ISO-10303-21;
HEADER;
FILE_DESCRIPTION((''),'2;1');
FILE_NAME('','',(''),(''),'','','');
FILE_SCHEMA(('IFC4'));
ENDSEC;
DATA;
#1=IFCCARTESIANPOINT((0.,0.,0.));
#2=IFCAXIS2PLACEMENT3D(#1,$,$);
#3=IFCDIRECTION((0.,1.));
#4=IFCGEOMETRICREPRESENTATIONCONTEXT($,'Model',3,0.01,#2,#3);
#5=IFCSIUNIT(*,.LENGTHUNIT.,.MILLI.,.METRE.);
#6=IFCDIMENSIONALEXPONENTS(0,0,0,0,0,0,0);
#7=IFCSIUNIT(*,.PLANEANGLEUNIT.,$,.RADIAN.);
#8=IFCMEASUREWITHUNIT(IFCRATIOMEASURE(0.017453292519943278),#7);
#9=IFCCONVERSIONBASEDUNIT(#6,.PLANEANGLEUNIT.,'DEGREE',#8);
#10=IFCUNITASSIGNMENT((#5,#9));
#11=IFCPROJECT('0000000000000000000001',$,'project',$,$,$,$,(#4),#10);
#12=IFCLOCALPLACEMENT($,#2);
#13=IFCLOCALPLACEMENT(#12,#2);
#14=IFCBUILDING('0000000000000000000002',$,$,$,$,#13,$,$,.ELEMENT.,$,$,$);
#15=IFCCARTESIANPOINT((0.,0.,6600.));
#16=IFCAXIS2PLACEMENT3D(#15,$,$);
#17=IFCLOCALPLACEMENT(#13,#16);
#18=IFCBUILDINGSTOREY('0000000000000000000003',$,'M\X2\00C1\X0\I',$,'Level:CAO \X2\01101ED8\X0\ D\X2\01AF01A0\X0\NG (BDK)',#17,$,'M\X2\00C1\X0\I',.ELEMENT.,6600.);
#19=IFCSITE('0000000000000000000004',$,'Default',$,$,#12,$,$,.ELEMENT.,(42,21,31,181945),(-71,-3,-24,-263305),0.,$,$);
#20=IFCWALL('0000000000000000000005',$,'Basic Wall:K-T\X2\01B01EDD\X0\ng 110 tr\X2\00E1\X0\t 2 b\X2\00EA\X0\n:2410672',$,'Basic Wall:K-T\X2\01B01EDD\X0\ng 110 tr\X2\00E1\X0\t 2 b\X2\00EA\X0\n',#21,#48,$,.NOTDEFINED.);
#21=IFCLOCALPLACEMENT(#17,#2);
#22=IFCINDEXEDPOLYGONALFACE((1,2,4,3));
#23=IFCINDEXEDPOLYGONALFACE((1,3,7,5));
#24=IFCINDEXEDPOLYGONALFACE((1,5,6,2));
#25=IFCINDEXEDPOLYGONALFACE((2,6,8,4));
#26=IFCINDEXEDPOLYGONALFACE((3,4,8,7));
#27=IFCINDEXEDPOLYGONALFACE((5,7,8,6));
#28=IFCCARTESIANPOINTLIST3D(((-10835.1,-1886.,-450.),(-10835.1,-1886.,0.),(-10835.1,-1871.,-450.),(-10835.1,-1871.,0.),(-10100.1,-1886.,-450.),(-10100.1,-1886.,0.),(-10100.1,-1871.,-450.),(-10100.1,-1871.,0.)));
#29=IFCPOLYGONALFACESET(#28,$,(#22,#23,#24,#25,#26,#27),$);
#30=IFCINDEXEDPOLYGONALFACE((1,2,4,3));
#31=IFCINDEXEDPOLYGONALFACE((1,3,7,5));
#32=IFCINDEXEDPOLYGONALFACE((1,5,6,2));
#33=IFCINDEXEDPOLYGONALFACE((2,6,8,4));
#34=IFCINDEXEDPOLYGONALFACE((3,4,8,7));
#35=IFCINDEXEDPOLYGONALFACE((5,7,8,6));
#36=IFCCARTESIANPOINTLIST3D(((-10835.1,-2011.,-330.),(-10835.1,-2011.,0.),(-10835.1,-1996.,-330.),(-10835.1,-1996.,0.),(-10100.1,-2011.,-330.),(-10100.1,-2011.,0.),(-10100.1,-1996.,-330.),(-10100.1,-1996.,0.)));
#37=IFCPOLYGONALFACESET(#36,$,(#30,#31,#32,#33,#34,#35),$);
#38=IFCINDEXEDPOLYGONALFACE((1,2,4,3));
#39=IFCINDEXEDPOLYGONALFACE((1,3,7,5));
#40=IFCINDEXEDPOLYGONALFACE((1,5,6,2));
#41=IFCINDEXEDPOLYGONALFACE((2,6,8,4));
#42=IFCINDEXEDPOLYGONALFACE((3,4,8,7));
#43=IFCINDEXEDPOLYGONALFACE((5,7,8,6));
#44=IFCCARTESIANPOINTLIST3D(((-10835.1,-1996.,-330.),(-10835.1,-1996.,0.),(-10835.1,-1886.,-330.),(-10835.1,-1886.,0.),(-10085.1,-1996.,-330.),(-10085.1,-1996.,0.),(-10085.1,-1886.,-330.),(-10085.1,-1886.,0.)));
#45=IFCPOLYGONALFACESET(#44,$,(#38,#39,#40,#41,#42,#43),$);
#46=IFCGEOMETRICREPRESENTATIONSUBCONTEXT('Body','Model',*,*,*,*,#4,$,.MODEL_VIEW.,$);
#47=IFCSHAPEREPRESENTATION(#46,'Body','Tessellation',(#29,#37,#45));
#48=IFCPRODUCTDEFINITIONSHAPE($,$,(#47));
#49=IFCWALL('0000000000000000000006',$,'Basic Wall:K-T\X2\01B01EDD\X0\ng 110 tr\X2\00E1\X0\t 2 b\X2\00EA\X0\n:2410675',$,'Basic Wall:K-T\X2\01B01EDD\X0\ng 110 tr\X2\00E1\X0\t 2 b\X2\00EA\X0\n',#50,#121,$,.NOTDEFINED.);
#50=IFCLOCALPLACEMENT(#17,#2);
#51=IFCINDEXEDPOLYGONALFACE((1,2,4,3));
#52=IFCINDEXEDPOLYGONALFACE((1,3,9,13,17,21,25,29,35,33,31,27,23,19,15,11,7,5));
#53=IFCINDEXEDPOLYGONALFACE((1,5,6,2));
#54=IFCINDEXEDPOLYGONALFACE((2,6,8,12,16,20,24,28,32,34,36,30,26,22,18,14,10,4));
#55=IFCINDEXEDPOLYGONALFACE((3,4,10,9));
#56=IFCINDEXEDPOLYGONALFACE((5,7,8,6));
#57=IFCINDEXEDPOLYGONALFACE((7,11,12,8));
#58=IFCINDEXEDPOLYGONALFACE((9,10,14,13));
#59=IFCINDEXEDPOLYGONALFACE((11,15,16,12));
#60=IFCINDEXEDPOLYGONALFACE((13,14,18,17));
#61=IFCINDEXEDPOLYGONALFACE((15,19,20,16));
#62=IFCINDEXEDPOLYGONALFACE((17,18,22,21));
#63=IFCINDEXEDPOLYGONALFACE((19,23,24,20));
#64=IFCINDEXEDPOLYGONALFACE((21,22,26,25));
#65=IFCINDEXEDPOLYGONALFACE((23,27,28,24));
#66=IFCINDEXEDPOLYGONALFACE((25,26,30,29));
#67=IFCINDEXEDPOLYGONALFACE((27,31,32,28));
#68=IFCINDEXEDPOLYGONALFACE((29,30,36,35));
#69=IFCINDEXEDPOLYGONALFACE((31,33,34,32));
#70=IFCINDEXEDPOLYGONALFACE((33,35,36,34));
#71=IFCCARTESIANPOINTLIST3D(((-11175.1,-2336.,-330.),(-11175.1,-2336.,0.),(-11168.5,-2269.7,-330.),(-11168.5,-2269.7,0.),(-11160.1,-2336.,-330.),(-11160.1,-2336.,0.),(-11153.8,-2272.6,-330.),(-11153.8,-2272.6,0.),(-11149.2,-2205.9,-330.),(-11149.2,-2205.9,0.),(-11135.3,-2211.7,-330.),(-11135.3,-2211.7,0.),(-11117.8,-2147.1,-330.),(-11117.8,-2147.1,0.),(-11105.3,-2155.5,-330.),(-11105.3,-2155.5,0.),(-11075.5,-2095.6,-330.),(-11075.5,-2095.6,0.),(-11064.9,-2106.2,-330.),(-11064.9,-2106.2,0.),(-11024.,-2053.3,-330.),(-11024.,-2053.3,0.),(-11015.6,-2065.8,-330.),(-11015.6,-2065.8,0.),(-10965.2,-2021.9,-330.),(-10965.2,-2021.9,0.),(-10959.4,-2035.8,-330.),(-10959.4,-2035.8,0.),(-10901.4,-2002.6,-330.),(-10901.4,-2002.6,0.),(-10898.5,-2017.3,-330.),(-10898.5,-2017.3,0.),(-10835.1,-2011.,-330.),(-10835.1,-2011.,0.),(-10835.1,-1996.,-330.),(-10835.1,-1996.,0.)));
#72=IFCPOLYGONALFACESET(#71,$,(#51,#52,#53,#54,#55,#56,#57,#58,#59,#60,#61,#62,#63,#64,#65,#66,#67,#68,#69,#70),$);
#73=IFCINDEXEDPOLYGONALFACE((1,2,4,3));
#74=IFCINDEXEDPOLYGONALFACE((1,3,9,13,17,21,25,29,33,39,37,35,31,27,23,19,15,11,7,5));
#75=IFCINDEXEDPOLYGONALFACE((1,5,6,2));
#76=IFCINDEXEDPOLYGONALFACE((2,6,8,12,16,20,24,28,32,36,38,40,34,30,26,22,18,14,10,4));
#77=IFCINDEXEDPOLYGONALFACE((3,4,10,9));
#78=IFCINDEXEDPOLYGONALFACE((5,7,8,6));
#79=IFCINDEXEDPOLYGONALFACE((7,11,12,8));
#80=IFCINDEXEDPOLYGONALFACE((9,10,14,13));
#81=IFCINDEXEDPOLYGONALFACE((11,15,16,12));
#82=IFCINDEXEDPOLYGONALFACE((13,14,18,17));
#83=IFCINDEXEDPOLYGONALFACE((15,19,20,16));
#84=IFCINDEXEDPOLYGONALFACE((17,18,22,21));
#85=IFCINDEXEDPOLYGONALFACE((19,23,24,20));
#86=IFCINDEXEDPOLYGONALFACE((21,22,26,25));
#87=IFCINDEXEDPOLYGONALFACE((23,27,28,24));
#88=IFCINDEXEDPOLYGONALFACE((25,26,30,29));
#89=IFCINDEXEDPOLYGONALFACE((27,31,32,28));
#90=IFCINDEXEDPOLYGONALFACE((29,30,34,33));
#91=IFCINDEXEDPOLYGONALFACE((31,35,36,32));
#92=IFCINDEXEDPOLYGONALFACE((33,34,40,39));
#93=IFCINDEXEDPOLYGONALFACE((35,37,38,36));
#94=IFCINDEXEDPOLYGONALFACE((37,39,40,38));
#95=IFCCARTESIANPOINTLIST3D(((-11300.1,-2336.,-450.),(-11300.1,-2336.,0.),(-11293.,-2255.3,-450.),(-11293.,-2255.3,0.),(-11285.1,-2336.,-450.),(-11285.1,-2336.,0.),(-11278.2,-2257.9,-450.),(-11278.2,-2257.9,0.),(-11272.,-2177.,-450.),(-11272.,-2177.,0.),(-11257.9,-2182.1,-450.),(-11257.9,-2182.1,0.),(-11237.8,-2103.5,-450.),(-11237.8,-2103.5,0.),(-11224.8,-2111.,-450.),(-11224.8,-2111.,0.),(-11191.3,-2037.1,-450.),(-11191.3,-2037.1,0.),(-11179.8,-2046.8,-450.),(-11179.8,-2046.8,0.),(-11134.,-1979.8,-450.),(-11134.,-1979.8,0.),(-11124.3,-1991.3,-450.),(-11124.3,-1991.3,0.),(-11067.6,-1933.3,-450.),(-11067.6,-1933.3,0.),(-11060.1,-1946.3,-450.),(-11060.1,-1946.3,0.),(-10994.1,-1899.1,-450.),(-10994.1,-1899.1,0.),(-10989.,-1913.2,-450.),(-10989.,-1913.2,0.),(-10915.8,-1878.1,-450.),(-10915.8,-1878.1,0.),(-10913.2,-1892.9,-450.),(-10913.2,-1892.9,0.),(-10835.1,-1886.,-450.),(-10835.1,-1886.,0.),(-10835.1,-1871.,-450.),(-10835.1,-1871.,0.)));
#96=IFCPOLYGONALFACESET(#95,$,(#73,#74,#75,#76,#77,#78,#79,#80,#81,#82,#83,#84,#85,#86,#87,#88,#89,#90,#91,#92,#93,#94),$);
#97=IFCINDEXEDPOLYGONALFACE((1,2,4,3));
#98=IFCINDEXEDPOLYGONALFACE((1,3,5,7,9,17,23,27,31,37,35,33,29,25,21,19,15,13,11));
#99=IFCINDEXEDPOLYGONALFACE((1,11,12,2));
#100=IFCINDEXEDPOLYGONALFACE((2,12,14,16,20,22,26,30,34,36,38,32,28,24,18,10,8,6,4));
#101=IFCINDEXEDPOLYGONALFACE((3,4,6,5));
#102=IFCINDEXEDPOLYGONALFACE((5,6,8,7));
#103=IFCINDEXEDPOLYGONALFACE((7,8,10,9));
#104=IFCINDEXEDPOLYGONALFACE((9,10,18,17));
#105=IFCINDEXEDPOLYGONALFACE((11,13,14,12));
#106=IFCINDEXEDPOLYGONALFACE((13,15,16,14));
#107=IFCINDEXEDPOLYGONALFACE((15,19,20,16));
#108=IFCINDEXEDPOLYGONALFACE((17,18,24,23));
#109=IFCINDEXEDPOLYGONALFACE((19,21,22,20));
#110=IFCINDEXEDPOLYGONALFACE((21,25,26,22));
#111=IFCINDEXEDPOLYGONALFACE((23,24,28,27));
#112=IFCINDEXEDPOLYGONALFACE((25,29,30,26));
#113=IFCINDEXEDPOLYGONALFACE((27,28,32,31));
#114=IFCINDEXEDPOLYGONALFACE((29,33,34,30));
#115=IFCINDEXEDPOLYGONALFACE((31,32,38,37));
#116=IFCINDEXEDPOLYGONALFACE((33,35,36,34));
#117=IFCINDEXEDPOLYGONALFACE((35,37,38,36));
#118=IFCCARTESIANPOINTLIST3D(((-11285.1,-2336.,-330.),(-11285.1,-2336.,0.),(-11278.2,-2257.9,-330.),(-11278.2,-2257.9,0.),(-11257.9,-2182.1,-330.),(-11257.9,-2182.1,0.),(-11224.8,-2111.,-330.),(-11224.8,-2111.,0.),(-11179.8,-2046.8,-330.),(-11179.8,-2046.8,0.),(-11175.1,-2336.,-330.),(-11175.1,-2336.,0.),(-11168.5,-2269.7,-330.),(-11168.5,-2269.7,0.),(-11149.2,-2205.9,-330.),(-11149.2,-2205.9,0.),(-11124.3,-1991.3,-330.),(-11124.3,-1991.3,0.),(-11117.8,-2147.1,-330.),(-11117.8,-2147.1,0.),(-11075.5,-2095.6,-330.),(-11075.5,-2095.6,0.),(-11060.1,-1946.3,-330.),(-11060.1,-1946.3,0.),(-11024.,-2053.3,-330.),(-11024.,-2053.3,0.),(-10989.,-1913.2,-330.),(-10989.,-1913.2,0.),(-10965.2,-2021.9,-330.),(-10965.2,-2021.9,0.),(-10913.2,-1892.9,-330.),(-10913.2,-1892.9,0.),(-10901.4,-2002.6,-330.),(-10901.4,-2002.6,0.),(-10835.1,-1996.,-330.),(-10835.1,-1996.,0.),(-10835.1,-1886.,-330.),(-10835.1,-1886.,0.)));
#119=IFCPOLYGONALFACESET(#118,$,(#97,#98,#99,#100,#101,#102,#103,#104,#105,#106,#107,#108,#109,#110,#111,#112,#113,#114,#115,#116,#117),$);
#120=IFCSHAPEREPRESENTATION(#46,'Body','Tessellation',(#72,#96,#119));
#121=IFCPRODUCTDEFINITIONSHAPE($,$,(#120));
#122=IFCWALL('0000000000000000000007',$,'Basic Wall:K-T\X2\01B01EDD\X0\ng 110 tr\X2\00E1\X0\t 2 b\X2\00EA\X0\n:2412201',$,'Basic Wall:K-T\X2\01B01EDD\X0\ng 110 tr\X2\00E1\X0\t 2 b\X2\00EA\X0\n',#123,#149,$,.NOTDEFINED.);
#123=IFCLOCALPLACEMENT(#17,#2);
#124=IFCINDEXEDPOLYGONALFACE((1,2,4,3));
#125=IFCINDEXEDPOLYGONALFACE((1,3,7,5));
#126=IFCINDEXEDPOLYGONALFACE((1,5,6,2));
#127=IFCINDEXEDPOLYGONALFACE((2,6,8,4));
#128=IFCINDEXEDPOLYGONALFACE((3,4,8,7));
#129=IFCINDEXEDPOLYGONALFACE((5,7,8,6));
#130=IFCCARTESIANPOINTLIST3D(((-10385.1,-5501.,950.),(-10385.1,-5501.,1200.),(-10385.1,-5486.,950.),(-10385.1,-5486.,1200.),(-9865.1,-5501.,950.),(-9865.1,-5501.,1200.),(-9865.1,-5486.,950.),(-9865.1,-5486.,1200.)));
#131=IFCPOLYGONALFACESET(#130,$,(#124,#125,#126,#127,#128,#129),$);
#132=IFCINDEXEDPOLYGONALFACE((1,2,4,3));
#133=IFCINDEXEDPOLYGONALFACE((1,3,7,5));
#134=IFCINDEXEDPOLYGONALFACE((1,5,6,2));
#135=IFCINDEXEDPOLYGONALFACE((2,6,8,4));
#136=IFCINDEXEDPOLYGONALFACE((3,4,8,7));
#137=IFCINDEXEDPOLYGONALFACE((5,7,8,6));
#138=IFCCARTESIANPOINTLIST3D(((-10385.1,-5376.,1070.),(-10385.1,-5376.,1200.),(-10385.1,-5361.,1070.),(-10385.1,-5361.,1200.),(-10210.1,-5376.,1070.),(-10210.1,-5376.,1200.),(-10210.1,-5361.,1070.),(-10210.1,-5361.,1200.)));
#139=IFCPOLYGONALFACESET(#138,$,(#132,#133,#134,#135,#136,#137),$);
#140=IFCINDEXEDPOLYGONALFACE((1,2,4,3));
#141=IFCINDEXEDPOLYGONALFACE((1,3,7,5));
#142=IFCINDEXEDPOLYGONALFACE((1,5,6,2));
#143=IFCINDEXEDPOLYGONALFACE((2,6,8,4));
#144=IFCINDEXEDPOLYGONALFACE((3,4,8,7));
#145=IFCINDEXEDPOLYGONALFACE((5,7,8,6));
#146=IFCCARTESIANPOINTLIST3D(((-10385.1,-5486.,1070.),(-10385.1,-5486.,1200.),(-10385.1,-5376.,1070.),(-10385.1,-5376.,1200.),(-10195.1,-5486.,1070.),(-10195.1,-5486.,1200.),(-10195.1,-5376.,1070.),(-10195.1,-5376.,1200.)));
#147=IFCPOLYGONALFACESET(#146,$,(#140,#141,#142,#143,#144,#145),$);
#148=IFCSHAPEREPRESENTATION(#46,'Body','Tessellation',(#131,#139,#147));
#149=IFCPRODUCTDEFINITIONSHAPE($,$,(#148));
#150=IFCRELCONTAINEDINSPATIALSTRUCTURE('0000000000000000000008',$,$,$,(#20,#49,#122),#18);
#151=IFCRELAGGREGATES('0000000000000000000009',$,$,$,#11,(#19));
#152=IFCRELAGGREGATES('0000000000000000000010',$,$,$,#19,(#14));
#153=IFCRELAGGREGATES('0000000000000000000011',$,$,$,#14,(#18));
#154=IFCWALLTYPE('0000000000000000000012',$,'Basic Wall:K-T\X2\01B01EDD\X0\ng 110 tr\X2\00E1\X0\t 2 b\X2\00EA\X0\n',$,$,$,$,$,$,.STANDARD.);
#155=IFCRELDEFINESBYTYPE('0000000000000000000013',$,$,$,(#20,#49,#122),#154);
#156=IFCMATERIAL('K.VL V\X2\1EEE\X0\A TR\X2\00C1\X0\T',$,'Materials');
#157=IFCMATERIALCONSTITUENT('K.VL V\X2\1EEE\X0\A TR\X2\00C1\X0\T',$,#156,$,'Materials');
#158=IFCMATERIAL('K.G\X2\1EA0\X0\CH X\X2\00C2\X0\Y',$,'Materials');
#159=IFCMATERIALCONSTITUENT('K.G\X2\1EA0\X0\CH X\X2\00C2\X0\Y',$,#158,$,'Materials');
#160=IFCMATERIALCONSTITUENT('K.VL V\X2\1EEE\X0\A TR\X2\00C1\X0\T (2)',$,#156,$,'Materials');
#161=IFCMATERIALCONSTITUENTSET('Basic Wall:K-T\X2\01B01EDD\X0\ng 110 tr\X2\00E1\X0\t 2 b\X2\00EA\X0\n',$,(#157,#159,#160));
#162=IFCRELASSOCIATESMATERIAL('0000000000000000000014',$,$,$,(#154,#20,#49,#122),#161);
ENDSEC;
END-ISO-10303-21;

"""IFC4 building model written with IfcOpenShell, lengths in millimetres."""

from ifc_helpers import new_model, entity, si_unit, converted_unit, direction, frame, origin, place, context, subcontext, project, spatial, line, arc, indexed_curve, outline, extrude, material, constituent, constituent_set, type_object, element, save


model = new_model("IFC4")

# Units and contexts
model_context = context("Model", 3, precision=0.01, world=origin(), true_north=direction((0.0, 1.0)))
body_context = subcontext(model_context, "Body", "Model", "MODEL_VIEW")
ifc_project = project(units=[si_unit("LENGTHUNIT", "METRE", prefix="MILLI"), converted_unit("PLANEANGLEUNIT", "DEGREE", entity("IfcRatioMeasure", 0.017453292519943278), si_unit("PLANEANGLEUNIT", "RADIAN"), dimensions=[0, 0, 0, 0, 0, 0, 0])], contexts=[model_context])

# Site, building, storey
site_placement = place(None, origin())
site = spatial("IfcSite", under=ifc_project, at=site_placement, Name="Default", CompositionType="ELEMENT", RefLatitude=(42, 21, 31, 181945), RefLongitude=(-71, -3, -24, -263305), RefElevation=0.0)
building_placement = place(site_placement, origin())
building = spatial("IfcBuilding", under=site, at=building_placement, CompositionType="ELEMENT")
storey_placement = place(building_placement, frame((0.0, 0.0, 6600.0)))
storey = spatial("IfcBuildingStorey", under=building, at=storey_placement, Name="MÁI", ObjectType="Level:CAO ĐỘ DƯƠNG (BDK)", LongName="MÁI", CompositionType="ELEMENT", Elevation=6600.0)

# Walls
ifc_material_1 = material(Name="K.VL VỮA TRÁT", Category="Materials")
ifc_material_2 = material(Name="K.GẠCH XÂY", Category="Materials")
ifc_constituent_1 = constituent(ifc_material_1, Name="K.VL VỮA TRÁT", Category="Materials")
ifc_constituent_2 = constituent(ifc_material_2, Name="K.GẠCH XÂY", Category="Materials")
ifc_constituent_3 = constituent(ifc_material_1, Name="K.VL VỮA TRÁT (2)", Category="Materials")
ifc_constituent_set_1 = constituent_set(constituents=[ifc_constituent_1, ifc_constituent_2, ifc_constituent_3], Name="Basic Wall:K-Tường 110 trát 2 bên")
wall_type_1 = type_object("IfcWallType", Name="Basic Wall:K-Tường 110 trát 2 bên", PredefinedType="STANDARD", material=ifc_constituent_set_1)
wall_1_placement = place(storey_placement, frame((-10100.1, -1941.0, -450.0), z_axis=(0.0, 0.0, 1.0), x_axis=(-1.0, 0.0, 0.0)))
element("IfcWall", 1, at=wall_1_placement, inside=storey, type_object=wall_type_1, material=ifc_constituent_set_1, Name="Basic Wall:K-Tường 110 trát 2 bên:2410672", ObjectType="Basic Wall:K-Tường 110 trát 2 bên", PredefinedType="NOTDEFINED", context=body_context, shape_type="SweptSolid", body=[
    extrude(outline(indexed_curve([(-7.5, -367.5), (7.5, -367.5), (7.5, 367.5), (-7.5, 367.5), (-7.5, -367.5)], self_intersect=False)), frame((367.5, -62.5, 0.0), z_axis=(0.0, 0.0, 1.0), x_axis=(0.0, 1.0, 0.0)), (0.0, 0.0, 1.0), 450.0),
    extrude(outline(indexed_curve([(-7.5, -165.0), (7.5, -165.0), (7.5, 165.0), (-7.5, 165.0), (-7.5, -165.0)], self_intersect=False)), frame((735.0, 62.5, 285.0), z_axis=(-1.0, 0.0, 0.0), x_axis=(0.0, -1.0, 0.0)), (0.0, 0.0, 1.0), 735.0),
    extrude(outline(indexed_curve([(-165.0, -55.0), (165.0, -55.0), (165.0, 55.0), (-165.0, 55.0), (-165.0, -55.0)], self_intersect=False)), frame((735.0, 0.0, 285.0), z_axis=(-1.0, 0.0, 0.0), x_axis=(0.0, 0.0, 1.0)), (0.0, 0.0, 1.0), 750.0),
])
wall_2_placement = place(storey_placement, frame((-11230.1, -2336.0, -450.0)))
element("IfcWall", 2, at=wall_2_placement, inside=storey, type_object=wall_type_1, material=ifc_constituent_set_1, Name="Basic Wall:K-Tường 110 trát 2 bên:2410675", ObjectType="Basic Wall:K-Tường 110 trát 2 bên", PredefinedType="NOTDEFINED", context=body_context, shape_type="SweptSolid", body=[
    extrude(outline(indexed_curve([(158.8, -166.2), (173.8, -166.3), (74.2, 74.2), (-166.3, 173.8), (-166.3, 158.8), (63.6, 63.6)], segments=[line(1, 2), arc(2, 3, 4), line(4, 5), arc(5, 6, 1)], self_intersect=False)), frame((228.7, 166.3, 120.0), z_axis=(0.0, 0.0, 1.0), x_axis=(0.0, 1.0, 0.0)), (0.0, 0.0, 1.0), 330.0),
    extrude(outline(indexed_curve([(-236.2, 228.8), (-100.1, -100.1), (228.7, -236.3), (228.8, -221.3), (-89.4, -89.4), (-221.2, 228.8)], segments=[arc(1, 2, 3), line(3, 4), arc(4, 5, 6), line(6, 1)], self_intersect=False)), frame((166.2, 228.8, 0.0), z_axis=(0.0, 0.0, -1.0), x_axis=(1.0, 0.0, 0.0)), (0.0, 0.0, -1.0), 450.0),
    extrude(outline(indexed_curve([(144.5, -196.0), (254.5, -194.9), (119.4, 121.9), (-200.1, 250.4), (-199.0, 140.4), (42.5, 43.4)], segments=[line(1, 2), arc(2, 3, 4), line(4, 5), arc(5, 6, 1)], self_intersect=False)), frame((197.5, 197.5, 120.0), z_axis=(0.0, 0.0, -1.0), x_axis=(-0.999946, -0.010416, 0.0)), (0.0, 0.0, -1.0), 330.0),
])
wall_3_placement = place(storey_placement, frame((-10385.1, -5431.0, 950.0)))
element("IfcWall", 3, at=wall_3_placement, inside=storey, type_object=wall_type_1, material=ifc_constituent_set_1, Name="Basic Wall:K-Tường 110 trát 2 bên:2412201", ObjectType="Basic Wall:K-Tường 110 trát 2 bên", PredefinedType="NOTDEFINED", context=body_context, shape_type="SweptSolid", body=[
    extrude(outline(indexed_curve([(-7.5, -260.0), (7.5, -260.0), (7.5, 260.0), (-7.5, 260.0), (-7.5, -260.0)], self_intersect=False)), frame((260.0, -62.5, 0.0), z_axis=(0.0, 0.0, 1.0), x_axis=(0.0, 1.0, 0.0)), (0.0, 0.0, 1.0), 250.0),
    extrude(outline(indexed_curve([(-7.5, -65.0), (7.5, -65.0), (7.5, 65.0), (-7.5, 65.0), (-7.5, -65.0)], self_intersect=False)), frame((0.0, 62.5, 185.0), z_axis=(1.0, 0.0, 0.0), x_axis=(0.0, -1.0, 0.0)), (0.0, 0.0, 1.0), 175.0),
    extrude(outline(indexed_curve([(-65.0, -55.0), (65.0, -55.0), (65.0, 55.0), (-65.0, 55.0), (-65.0, -55.0)], self_intersect=False)), frame((0.0, 0.0, 185.0), z_axis=(1.0, 0.0, 0.0), x_axis=(0.0, 0.0, -1.0)), (0.0, 0.0, 1.0), 190.0),
])

save(model, "model.ifc")
